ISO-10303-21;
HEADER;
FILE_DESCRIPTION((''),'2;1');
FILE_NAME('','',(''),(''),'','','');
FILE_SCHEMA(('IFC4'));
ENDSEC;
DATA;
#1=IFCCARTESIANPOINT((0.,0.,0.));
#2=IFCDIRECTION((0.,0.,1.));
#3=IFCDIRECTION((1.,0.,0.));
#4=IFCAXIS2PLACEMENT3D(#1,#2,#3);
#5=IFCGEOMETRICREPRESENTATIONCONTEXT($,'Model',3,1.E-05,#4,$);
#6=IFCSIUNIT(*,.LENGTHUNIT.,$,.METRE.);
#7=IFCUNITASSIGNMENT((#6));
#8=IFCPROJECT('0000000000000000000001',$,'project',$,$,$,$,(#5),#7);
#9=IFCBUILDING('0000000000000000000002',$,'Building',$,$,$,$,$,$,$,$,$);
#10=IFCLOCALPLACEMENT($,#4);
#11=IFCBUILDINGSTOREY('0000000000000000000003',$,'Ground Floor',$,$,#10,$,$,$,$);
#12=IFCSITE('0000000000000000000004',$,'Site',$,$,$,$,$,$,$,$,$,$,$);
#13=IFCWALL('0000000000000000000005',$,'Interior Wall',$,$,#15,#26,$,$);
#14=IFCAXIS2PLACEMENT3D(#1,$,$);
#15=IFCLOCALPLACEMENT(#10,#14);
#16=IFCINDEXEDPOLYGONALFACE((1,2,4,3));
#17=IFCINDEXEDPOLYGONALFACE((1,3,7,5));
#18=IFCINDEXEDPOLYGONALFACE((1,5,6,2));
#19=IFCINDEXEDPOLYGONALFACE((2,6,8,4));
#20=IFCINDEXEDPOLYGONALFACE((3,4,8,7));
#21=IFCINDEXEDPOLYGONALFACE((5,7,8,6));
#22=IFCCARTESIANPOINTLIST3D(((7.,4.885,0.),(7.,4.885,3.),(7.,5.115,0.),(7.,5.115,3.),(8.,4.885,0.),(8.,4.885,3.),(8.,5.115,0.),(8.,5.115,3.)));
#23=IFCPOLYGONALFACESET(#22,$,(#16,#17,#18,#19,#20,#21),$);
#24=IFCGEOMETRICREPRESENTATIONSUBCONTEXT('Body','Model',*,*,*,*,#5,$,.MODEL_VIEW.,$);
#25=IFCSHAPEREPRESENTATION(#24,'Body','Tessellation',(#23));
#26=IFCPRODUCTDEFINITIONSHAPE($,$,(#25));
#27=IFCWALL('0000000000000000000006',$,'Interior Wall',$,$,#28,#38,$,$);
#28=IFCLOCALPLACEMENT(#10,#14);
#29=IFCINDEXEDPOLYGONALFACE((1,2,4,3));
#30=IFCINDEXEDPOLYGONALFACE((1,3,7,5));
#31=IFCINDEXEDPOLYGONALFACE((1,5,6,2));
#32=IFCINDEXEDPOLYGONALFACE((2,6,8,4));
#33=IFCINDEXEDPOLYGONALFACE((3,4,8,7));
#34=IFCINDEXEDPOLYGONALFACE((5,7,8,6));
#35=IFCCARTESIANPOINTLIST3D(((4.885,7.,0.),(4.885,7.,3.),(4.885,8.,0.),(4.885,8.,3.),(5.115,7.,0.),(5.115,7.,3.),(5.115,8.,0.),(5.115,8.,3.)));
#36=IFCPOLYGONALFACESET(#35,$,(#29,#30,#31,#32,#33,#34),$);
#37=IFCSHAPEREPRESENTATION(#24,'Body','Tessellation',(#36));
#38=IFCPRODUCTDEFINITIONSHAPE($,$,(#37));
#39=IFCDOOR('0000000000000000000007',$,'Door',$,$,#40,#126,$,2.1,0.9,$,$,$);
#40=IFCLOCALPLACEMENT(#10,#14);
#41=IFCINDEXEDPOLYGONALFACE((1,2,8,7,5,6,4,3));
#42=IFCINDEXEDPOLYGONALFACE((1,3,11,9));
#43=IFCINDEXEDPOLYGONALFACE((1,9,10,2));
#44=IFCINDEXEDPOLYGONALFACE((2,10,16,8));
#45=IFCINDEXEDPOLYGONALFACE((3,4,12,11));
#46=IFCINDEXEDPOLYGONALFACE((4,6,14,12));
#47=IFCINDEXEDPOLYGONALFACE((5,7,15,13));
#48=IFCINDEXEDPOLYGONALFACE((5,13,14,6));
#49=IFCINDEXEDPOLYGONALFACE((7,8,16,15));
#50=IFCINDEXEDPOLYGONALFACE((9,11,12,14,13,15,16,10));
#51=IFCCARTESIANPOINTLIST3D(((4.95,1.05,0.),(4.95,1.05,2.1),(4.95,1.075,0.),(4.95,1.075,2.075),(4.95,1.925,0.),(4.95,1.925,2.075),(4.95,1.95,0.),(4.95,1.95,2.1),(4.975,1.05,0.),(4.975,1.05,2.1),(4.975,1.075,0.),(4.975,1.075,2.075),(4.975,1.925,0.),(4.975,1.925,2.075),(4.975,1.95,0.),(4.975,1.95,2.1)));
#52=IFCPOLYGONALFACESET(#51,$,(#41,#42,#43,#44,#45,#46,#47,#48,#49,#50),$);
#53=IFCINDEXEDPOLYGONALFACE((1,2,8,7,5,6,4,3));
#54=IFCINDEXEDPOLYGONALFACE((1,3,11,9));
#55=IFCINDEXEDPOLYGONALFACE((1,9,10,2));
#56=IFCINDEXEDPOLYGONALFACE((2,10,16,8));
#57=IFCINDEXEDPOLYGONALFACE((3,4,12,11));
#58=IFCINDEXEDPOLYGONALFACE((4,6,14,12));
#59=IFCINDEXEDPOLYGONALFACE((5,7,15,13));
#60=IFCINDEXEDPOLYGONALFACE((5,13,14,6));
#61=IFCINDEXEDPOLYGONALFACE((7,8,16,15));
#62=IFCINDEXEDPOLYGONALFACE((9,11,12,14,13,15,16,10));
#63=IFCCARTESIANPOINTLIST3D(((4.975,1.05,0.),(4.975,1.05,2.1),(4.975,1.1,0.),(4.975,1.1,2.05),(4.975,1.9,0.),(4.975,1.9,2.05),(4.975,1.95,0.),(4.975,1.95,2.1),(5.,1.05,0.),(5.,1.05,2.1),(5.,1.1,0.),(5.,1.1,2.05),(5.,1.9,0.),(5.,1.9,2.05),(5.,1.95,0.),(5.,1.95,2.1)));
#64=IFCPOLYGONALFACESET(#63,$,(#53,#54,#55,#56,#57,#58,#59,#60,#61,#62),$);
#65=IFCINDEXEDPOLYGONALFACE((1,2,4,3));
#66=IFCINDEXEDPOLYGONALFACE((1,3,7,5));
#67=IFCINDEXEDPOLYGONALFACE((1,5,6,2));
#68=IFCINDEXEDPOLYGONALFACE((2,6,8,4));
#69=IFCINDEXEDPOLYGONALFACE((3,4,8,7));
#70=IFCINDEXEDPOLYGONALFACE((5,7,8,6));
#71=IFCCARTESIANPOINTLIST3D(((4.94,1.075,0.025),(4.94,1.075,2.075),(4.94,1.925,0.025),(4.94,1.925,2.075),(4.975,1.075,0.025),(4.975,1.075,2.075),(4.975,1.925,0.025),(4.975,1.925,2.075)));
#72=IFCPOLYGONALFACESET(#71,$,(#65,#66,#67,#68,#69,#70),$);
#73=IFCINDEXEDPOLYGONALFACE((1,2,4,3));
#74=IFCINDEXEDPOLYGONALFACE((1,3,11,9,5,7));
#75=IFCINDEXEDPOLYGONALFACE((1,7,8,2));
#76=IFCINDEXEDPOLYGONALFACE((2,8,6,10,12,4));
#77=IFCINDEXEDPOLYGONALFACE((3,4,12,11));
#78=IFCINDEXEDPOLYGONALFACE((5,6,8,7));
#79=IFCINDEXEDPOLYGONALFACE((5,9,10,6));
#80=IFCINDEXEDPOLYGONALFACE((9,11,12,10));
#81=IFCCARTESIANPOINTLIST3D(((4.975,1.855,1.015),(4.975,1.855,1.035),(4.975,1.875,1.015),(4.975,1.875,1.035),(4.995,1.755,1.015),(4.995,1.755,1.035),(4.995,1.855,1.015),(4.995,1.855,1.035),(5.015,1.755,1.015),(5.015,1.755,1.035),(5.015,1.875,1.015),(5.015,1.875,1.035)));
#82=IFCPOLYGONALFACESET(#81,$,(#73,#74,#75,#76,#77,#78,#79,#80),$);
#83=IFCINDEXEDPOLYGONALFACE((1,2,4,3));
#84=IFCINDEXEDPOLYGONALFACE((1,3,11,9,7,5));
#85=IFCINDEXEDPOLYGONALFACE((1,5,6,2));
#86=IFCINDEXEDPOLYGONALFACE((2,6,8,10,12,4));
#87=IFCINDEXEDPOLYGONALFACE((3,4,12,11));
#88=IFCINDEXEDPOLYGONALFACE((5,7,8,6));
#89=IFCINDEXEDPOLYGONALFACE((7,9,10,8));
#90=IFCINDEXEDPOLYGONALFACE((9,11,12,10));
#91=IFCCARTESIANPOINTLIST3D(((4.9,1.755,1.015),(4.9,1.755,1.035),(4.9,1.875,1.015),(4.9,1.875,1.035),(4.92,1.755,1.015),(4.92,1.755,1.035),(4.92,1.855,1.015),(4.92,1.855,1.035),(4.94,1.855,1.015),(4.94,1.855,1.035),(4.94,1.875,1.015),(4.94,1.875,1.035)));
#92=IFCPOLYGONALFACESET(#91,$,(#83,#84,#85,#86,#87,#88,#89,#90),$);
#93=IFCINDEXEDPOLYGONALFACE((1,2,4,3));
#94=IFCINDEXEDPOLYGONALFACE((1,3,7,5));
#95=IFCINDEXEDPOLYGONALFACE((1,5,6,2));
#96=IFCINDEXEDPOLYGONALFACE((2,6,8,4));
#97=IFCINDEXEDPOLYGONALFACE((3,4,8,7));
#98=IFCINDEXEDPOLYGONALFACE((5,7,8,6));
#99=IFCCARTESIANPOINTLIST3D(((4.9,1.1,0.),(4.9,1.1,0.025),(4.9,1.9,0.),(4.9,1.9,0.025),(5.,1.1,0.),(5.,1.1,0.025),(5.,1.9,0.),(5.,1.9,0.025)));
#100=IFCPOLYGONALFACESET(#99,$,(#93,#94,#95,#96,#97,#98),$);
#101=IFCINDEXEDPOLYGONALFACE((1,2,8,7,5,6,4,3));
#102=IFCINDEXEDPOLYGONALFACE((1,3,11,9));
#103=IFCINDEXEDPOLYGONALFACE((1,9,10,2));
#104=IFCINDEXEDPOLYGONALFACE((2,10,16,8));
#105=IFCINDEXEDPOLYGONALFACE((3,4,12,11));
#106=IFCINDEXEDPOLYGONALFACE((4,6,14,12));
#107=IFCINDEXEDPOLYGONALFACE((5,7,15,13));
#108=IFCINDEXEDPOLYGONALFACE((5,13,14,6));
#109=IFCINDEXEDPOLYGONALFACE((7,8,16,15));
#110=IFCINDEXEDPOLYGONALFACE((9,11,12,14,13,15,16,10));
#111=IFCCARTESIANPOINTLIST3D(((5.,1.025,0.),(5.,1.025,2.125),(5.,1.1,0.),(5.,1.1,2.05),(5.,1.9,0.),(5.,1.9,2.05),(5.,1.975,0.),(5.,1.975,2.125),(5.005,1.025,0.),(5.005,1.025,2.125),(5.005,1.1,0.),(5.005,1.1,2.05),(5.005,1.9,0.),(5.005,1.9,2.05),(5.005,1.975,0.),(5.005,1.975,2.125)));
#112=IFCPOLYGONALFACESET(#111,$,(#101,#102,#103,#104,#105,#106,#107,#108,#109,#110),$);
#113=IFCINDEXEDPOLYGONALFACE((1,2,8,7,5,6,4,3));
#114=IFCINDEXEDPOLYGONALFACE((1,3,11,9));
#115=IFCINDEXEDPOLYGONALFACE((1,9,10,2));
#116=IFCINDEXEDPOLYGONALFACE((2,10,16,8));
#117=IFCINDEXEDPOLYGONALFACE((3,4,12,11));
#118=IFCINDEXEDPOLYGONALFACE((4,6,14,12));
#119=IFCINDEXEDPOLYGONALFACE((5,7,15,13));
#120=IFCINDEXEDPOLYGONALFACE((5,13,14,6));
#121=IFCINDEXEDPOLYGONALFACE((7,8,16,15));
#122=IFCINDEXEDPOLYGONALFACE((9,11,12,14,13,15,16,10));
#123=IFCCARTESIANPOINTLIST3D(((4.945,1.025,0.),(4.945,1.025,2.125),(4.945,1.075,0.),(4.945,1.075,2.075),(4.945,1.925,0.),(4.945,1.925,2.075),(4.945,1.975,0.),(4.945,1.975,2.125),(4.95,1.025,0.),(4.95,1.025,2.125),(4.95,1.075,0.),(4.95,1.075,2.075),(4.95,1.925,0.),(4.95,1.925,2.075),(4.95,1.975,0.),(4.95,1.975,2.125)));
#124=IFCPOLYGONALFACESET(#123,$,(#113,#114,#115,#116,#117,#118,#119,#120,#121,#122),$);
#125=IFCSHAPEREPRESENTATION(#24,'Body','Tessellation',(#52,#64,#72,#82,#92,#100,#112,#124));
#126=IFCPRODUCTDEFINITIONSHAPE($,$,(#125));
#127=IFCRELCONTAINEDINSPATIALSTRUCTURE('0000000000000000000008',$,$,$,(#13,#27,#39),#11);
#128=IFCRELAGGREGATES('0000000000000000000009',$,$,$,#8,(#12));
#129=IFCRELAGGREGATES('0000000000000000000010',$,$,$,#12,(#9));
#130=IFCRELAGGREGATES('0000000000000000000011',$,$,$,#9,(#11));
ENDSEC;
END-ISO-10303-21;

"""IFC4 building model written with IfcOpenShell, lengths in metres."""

from ifc_helpers import new_model, si_unit, frame, origin_with_axes, place, context, subcontext, project, spatial, line, indexed_curve, outline, extrude, element, save


model = new_model("IFC4")

# Units and contexts
model_context = context("Model", 3, precision=1e-05, world=origin_with_axes())
body_context = subcontext(model_context, "Body", "Model", "MODEL_VIEW")
ifc_project = project(units=[si_unit("LENGTHUNIT", "METRE")], contexts=[model_context])

# Site, building, storey
site = spatial("IfcSite", under=ifc_project, Name="Site")
building = spatial("IfcBuilding", under=site, Name="Building")
storey_placement = place(None, origin_with_axes())
storey = spatial("IfcBuildingStorey", under=building, at=storey_placement, Name="Ground Floor")

# Walls
for number, where, z_axis, x_axis, name in (
    (1, (8.0, 5.0, 0.0), (0.0, 0.0, 1.0), (-1.0, 0.0, 0.0), "Interior Wall"),
    (2, (5.0, 8.0, 0.0), (0.0, 0.0, 1.0), (0.0, -1.0, 0.0), "Interior Wall"),
):
    element("IfcWall", number, at=place(storey_placement, frame(where, z_axis=z_axis, x_axis=x_axis)), inside=storey, Name=name, context=body_context, shape_type="SweptSolid", body=[
        extrude(outline(indexed_curve([(0.0, 0.0), (0.0, 0.23), (1.0, 0.23), (1.0, 0.0), (0.0, 0.0)], self_intersect=False)), frame((0.0, -0.115, 0.0), z_axis=(0.0, 0.0, 1.0), x_axis=(1.0, 0.0, 0.0)), (0.0, 0.0, 1.0), 3.0),
    ])

# Door
door_1_placement = place(storey_placement, frame((5.0, 1.05, 0.0), z_axis=(0.0, 0.0, 1.0), x_axis=(0.0, 1.0, 0.0)))
element("IfcDoor", 3, at=door_1_placement, inside=storey, Name="Door", OverallHeight=2.1, OverallWidth=0.9, context=body_context, shape_type="SweptSolid", body=[
    extrude(outline(indexed_curve([(0.0, 0.0), (0.0, 2.1), (0.9, 2.1), (0.9, 0.0), (0.875, 0.0), (0.875, 2.075), (0.025, 2.075), (0.025, 0.0)], segments=[line(1, 2, 3, 4, 5, 6, 7, 8, 1)])), frame((0.0, 0.025, 0.0), z_axis=(0.0, -1.0, 0.0), x_axis=(1.0, 0.0, 0.0)), (0.0, 0.0, -1.0), 0.025),
    extrude(outline(indexed_curve([(0.0, 0.0), (0.0, 2.1), (0.9, 2.1), (0.9, 0.0), (0.85, 0.0), (0.85, 2.05), (0.05, 2.05), (0.05, 0.0)], segments=[line(1, 2, 3, 4, 5, 6, 7, 8, 1)])), frame((0.0, 0.0, 0.0), z_axis=(0.0, -1.0, 0.0), x_axis=(1.0, 0.0, 0.0)), (0.0, 0.0, -1.0), 0.025),
    extrude(outline(indexed_curve([(0.0, 0.0), (0.85, 0.0), (0.85, 0.035), (0.0, 0.035)], segments=[line(1, 2, 3, 4, 1)])), frame((0.025, 0.025, 0.025), z_axis=(0.0, 0.0, 1.0), x_axis=(1.0, 0.0, 0.0)), (0.0, 0.0, 1.0), 2.05),
    extrude(outline(indexed_curve([(0.0, 0.0), (0.0, -0.04), (-0.12, -0.04), (-0.12, -0.02), (-0.02, -0.02), (-0.02, 0.0)], segments=[line(1, 2, 3, 4, 5, 6, 1)])), frame((0.825, 0.025, 1.015), z_axis=(0.0, 0.0, 1.0), x_axis=(1.0, 0.0, 0.0)), (0.0, 0.0, 1.0), 0.02),
    extrude(outline(indexed_curve([(0.0, 0.0), (0.0, 0.04), (-0.12, 0.04), (-0.12, 0.02), (-0.02, 0.02), (-0.02, 0.0)], segments=[line(1, 2, 3, 4, 5, 6, 1)])), frame((0.825, 0.06, 1.015), z_axis=(0.0, 0.0, 1.0), x_axis=(1.0, 0.0, 0.0)), (0.0, 0.0, 1.0), 0.02),
    extrude(outline(indexed_curve([(0.0, 0.0), (0.8, 0.0), (0.8, 0.1), (0.0, 0.1)], segments=[line(1, 2, 3, 4, 1)])), frame((0.05, 0.0, 0.0), z_axis=(0.0, 0.0, 1.0), x_axis=(1.0, 0.0, 0.0)), (0.0, 0.0, 1.0), 0.025),
    extrude(outline(indexed_curve([(0.0, 0.0), (0.0, 2.125), (0.95, 2.125), (0.95, 0.0), (0.875, 0.0), (0.875, 2.05), (0.075, 2.05), (0.075, 0.0)], segments=[line(1, 2, 3, 4, 5, 6, 7, 8, 1)])), frame((-0.025, -0.005, 0.0), z_axis=(0.0, -1.0, 0.0), x_axis=(1.0, 0.0, 0.0)), (0.0, 0.0, -1.0), 0.005),
    extrude(outline(indexed_curve([(0.0, 0.0), (0.0, 2.125), (0.95, 2.125), (0.95, 0.0), (0.9, 0.0), (0.9, 2.075), (0.05, 2.075), (0.05, 0.0)], segments=[line(1, 2, 3, 4, 5, 6, 7, 8, 1)])), frame((-0.025, 0.05, 0.0), z_axis=(0.0, -1.0, 0.0), x_axis=(1.0, 0.0, 0.0)), (0.0, 0.0, -1.0), 0.005),
])

save(model, "model.ifc")
